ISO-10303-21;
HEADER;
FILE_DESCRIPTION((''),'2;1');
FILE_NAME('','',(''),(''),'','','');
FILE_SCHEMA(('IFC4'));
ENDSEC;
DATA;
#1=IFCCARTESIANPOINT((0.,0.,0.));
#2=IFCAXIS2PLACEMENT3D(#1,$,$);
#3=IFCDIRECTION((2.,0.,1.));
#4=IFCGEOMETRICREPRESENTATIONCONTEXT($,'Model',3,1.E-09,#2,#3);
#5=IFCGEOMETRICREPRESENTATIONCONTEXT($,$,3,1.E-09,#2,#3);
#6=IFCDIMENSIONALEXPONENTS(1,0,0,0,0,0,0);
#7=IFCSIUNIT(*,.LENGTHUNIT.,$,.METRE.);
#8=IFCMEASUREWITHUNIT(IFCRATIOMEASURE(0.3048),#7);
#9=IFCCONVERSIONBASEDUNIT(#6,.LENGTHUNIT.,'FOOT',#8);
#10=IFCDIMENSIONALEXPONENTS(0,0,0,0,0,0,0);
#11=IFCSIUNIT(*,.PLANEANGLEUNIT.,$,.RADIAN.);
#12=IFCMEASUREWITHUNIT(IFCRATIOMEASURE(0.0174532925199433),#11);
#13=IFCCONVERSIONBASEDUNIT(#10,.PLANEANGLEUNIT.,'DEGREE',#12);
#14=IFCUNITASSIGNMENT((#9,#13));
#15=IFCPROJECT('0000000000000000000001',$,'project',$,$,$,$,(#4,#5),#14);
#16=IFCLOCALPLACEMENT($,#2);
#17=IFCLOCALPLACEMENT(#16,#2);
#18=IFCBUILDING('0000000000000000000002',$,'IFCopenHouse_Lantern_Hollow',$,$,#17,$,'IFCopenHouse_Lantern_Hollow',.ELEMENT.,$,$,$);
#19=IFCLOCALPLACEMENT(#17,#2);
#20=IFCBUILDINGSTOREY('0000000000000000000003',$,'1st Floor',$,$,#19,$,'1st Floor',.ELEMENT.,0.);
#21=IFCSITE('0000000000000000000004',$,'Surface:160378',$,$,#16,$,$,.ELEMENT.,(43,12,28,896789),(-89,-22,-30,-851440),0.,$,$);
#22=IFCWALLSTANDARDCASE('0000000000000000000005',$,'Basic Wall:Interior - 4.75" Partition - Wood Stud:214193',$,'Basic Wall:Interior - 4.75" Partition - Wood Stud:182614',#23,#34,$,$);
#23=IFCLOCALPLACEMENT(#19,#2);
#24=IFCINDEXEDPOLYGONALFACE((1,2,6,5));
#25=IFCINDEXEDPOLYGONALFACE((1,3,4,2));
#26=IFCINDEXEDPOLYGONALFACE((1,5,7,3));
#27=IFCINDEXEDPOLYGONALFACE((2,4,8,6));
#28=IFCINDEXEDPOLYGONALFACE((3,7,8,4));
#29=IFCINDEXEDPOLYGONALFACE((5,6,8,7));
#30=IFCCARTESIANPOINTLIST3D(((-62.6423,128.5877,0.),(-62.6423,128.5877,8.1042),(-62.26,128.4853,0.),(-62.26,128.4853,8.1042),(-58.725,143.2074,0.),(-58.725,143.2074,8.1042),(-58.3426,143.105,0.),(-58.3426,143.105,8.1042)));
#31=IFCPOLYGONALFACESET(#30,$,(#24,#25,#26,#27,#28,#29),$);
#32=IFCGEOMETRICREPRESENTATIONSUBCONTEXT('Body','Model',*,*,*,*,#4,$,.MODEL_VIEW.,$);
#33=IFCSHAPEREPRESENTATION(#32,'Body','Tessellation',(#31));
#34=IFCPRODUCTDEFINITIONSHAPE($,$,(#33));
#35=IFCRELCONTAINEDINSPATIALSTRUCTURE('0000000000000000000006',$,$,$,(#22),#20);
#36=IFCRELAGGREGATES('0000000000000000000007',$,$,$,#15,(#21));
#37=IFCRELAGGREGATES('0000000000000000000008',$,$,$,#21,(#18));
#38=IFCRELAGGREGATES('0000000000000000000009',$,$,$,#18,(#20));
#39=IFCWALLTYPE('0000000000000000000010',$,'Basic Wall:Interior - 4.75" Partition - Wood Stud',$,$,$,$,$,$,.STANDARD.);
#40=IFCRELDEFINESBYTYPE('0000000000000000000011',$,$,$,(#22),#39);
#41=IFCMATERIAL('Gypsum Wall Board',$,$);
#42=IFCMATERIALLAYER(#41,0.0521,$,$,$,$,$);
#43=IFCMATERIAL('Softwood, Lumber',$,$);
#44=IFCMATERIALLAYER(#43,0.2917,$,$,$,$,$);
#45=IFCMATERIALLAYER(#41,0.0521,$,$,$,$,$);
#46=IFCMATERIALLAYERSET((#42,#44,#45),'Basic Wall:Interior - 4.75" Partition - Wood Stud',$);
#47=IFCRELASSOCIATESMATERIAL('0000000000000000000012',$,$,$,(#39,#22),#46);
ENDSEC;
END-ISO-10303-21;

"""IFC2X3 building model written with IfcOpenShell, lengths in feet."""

from ifc_helpers import new_model, entity, si_unit, converted_unit, direction, frame, frame_2d, origin, place, context, subcontext, project, spatial, rectangle, extrude, material, layer, layer_set, layer_usage, type_object, element, save


model = new_model("IFC2X3")

# Units and contexts
model_context = context("Model", 3, precision=1e-09, world=origin(), true_north=direction((2.0, 0.0, 1.0)))
context_of_model = context(None, 3, precision=1e-09, world=origin(), true_north=direction((2.0, 0.0, 1.0)))
body_context = subcontext(model_context, "Body", "Model", "MODEL_VIEW")
ifc_project = project(units=[converted_unit("LENGTHUNIT", "FOOT", entity("IfcRatioMeasure", 0.3048), si_unit("LENGTHUNIT", "METRE"), dimensions=[1, 0, 0, 0, 0, 0, 0]), converted_unit("PLANEANGLEUNIT", "DEGREE", entity("IfcRatioMeasure", 0.0174532925199433), si_unit("PLANEANGLEUNIT", "RADIAN"), dimensions=[0, 0, 0, 0, 0, 0, 0])], contexts=[model_context, context_of_model])

# Site, building, storey
site_placement = place(None, origin())
site = spatial("IfcSite", under=ifc_project, at=site_placement, Name="Surface:160378", CompositionType="ELEMENT", RefLatitude=(43, 12, 28, 896789), RefLongitude=(-89, -22, -30, -851440), RefElevation=0.0)
building_placement = place(site_placement, origin())
building = spatial("IfcBuilding", under=site, at=building_placement, Name="IFCopenHouse_Lantern_Hollow", LongName="IFCopenHouse_Lantern_Hollow", CompositionType="ELEMENT")
storey_placement = place(building_placement, origin())
storey = spatial("IfcBuildingStorey", under=building, at=storey_placement, Name="1st Floor", LongName="1st Floor", CompositionType="ELEMENT", Elevation=0.0)

# Shared definitions
ifc_material_1 = material(Name="Softwood, Lumber")

# Shared definitions
ifc_material_2 = material(Name="Gypsum Wall Board")

# Wall
ifc_layer_1 = layer(ifc_material_2, 0.0521)
ifc_layer_2 = layer(ifc_material_1, 0.2917)
ifc_layer_3 = layer(ifc_material_2, 0.0521)
ifc_layer_set_1 = layer_set([ifc_layer_1, ifc_layer_2, ifc_layer_3], Name="Basic Wall:Interior - 4.75\" Partition - Wood Stud")
ifc_layer_usage_1 = layer_usage(ifc_layer_set_1, "AXIS2", "NEGATIVE", 0.1979)
wall_type_1 = type_object("IfcWallType", Name="Basic Wall:Interior - 4.75\" Partition - Wood Stud", PredefinedType="STANDARD", material=ifc_layer_set_1)
wall_1_placement = place(storey_placement, frame((-62.4511, 128.5365, 0.0), z_axis=(0.0, 0.0, 1.0), x_axis=(0.258819, 0.965926, 0.0)))
element("IfcWallStandardCase", 1, at=wall_1_placement, inside=storey, type_object=wall_type_1, material=ifc_layer_usage_1, Name="Basic Wall:Interior - 4.75\" Partition - Wood Stud:214193", ObjectType="Basic Wall:Interior - 4.75\" Partition - Wood Stud:182614", context=body_context, shape_type="SweptSolid", body=[
    extrude(rectangle(XDim=15.1354, YDim=0.3958, at=frame_2d((7.5677, 0.0), x_axis=(-1.0, 0.0))), origin(), (0.0, 0.0, 1.0), 8.1042),
])

save(model, "model.ifc")
